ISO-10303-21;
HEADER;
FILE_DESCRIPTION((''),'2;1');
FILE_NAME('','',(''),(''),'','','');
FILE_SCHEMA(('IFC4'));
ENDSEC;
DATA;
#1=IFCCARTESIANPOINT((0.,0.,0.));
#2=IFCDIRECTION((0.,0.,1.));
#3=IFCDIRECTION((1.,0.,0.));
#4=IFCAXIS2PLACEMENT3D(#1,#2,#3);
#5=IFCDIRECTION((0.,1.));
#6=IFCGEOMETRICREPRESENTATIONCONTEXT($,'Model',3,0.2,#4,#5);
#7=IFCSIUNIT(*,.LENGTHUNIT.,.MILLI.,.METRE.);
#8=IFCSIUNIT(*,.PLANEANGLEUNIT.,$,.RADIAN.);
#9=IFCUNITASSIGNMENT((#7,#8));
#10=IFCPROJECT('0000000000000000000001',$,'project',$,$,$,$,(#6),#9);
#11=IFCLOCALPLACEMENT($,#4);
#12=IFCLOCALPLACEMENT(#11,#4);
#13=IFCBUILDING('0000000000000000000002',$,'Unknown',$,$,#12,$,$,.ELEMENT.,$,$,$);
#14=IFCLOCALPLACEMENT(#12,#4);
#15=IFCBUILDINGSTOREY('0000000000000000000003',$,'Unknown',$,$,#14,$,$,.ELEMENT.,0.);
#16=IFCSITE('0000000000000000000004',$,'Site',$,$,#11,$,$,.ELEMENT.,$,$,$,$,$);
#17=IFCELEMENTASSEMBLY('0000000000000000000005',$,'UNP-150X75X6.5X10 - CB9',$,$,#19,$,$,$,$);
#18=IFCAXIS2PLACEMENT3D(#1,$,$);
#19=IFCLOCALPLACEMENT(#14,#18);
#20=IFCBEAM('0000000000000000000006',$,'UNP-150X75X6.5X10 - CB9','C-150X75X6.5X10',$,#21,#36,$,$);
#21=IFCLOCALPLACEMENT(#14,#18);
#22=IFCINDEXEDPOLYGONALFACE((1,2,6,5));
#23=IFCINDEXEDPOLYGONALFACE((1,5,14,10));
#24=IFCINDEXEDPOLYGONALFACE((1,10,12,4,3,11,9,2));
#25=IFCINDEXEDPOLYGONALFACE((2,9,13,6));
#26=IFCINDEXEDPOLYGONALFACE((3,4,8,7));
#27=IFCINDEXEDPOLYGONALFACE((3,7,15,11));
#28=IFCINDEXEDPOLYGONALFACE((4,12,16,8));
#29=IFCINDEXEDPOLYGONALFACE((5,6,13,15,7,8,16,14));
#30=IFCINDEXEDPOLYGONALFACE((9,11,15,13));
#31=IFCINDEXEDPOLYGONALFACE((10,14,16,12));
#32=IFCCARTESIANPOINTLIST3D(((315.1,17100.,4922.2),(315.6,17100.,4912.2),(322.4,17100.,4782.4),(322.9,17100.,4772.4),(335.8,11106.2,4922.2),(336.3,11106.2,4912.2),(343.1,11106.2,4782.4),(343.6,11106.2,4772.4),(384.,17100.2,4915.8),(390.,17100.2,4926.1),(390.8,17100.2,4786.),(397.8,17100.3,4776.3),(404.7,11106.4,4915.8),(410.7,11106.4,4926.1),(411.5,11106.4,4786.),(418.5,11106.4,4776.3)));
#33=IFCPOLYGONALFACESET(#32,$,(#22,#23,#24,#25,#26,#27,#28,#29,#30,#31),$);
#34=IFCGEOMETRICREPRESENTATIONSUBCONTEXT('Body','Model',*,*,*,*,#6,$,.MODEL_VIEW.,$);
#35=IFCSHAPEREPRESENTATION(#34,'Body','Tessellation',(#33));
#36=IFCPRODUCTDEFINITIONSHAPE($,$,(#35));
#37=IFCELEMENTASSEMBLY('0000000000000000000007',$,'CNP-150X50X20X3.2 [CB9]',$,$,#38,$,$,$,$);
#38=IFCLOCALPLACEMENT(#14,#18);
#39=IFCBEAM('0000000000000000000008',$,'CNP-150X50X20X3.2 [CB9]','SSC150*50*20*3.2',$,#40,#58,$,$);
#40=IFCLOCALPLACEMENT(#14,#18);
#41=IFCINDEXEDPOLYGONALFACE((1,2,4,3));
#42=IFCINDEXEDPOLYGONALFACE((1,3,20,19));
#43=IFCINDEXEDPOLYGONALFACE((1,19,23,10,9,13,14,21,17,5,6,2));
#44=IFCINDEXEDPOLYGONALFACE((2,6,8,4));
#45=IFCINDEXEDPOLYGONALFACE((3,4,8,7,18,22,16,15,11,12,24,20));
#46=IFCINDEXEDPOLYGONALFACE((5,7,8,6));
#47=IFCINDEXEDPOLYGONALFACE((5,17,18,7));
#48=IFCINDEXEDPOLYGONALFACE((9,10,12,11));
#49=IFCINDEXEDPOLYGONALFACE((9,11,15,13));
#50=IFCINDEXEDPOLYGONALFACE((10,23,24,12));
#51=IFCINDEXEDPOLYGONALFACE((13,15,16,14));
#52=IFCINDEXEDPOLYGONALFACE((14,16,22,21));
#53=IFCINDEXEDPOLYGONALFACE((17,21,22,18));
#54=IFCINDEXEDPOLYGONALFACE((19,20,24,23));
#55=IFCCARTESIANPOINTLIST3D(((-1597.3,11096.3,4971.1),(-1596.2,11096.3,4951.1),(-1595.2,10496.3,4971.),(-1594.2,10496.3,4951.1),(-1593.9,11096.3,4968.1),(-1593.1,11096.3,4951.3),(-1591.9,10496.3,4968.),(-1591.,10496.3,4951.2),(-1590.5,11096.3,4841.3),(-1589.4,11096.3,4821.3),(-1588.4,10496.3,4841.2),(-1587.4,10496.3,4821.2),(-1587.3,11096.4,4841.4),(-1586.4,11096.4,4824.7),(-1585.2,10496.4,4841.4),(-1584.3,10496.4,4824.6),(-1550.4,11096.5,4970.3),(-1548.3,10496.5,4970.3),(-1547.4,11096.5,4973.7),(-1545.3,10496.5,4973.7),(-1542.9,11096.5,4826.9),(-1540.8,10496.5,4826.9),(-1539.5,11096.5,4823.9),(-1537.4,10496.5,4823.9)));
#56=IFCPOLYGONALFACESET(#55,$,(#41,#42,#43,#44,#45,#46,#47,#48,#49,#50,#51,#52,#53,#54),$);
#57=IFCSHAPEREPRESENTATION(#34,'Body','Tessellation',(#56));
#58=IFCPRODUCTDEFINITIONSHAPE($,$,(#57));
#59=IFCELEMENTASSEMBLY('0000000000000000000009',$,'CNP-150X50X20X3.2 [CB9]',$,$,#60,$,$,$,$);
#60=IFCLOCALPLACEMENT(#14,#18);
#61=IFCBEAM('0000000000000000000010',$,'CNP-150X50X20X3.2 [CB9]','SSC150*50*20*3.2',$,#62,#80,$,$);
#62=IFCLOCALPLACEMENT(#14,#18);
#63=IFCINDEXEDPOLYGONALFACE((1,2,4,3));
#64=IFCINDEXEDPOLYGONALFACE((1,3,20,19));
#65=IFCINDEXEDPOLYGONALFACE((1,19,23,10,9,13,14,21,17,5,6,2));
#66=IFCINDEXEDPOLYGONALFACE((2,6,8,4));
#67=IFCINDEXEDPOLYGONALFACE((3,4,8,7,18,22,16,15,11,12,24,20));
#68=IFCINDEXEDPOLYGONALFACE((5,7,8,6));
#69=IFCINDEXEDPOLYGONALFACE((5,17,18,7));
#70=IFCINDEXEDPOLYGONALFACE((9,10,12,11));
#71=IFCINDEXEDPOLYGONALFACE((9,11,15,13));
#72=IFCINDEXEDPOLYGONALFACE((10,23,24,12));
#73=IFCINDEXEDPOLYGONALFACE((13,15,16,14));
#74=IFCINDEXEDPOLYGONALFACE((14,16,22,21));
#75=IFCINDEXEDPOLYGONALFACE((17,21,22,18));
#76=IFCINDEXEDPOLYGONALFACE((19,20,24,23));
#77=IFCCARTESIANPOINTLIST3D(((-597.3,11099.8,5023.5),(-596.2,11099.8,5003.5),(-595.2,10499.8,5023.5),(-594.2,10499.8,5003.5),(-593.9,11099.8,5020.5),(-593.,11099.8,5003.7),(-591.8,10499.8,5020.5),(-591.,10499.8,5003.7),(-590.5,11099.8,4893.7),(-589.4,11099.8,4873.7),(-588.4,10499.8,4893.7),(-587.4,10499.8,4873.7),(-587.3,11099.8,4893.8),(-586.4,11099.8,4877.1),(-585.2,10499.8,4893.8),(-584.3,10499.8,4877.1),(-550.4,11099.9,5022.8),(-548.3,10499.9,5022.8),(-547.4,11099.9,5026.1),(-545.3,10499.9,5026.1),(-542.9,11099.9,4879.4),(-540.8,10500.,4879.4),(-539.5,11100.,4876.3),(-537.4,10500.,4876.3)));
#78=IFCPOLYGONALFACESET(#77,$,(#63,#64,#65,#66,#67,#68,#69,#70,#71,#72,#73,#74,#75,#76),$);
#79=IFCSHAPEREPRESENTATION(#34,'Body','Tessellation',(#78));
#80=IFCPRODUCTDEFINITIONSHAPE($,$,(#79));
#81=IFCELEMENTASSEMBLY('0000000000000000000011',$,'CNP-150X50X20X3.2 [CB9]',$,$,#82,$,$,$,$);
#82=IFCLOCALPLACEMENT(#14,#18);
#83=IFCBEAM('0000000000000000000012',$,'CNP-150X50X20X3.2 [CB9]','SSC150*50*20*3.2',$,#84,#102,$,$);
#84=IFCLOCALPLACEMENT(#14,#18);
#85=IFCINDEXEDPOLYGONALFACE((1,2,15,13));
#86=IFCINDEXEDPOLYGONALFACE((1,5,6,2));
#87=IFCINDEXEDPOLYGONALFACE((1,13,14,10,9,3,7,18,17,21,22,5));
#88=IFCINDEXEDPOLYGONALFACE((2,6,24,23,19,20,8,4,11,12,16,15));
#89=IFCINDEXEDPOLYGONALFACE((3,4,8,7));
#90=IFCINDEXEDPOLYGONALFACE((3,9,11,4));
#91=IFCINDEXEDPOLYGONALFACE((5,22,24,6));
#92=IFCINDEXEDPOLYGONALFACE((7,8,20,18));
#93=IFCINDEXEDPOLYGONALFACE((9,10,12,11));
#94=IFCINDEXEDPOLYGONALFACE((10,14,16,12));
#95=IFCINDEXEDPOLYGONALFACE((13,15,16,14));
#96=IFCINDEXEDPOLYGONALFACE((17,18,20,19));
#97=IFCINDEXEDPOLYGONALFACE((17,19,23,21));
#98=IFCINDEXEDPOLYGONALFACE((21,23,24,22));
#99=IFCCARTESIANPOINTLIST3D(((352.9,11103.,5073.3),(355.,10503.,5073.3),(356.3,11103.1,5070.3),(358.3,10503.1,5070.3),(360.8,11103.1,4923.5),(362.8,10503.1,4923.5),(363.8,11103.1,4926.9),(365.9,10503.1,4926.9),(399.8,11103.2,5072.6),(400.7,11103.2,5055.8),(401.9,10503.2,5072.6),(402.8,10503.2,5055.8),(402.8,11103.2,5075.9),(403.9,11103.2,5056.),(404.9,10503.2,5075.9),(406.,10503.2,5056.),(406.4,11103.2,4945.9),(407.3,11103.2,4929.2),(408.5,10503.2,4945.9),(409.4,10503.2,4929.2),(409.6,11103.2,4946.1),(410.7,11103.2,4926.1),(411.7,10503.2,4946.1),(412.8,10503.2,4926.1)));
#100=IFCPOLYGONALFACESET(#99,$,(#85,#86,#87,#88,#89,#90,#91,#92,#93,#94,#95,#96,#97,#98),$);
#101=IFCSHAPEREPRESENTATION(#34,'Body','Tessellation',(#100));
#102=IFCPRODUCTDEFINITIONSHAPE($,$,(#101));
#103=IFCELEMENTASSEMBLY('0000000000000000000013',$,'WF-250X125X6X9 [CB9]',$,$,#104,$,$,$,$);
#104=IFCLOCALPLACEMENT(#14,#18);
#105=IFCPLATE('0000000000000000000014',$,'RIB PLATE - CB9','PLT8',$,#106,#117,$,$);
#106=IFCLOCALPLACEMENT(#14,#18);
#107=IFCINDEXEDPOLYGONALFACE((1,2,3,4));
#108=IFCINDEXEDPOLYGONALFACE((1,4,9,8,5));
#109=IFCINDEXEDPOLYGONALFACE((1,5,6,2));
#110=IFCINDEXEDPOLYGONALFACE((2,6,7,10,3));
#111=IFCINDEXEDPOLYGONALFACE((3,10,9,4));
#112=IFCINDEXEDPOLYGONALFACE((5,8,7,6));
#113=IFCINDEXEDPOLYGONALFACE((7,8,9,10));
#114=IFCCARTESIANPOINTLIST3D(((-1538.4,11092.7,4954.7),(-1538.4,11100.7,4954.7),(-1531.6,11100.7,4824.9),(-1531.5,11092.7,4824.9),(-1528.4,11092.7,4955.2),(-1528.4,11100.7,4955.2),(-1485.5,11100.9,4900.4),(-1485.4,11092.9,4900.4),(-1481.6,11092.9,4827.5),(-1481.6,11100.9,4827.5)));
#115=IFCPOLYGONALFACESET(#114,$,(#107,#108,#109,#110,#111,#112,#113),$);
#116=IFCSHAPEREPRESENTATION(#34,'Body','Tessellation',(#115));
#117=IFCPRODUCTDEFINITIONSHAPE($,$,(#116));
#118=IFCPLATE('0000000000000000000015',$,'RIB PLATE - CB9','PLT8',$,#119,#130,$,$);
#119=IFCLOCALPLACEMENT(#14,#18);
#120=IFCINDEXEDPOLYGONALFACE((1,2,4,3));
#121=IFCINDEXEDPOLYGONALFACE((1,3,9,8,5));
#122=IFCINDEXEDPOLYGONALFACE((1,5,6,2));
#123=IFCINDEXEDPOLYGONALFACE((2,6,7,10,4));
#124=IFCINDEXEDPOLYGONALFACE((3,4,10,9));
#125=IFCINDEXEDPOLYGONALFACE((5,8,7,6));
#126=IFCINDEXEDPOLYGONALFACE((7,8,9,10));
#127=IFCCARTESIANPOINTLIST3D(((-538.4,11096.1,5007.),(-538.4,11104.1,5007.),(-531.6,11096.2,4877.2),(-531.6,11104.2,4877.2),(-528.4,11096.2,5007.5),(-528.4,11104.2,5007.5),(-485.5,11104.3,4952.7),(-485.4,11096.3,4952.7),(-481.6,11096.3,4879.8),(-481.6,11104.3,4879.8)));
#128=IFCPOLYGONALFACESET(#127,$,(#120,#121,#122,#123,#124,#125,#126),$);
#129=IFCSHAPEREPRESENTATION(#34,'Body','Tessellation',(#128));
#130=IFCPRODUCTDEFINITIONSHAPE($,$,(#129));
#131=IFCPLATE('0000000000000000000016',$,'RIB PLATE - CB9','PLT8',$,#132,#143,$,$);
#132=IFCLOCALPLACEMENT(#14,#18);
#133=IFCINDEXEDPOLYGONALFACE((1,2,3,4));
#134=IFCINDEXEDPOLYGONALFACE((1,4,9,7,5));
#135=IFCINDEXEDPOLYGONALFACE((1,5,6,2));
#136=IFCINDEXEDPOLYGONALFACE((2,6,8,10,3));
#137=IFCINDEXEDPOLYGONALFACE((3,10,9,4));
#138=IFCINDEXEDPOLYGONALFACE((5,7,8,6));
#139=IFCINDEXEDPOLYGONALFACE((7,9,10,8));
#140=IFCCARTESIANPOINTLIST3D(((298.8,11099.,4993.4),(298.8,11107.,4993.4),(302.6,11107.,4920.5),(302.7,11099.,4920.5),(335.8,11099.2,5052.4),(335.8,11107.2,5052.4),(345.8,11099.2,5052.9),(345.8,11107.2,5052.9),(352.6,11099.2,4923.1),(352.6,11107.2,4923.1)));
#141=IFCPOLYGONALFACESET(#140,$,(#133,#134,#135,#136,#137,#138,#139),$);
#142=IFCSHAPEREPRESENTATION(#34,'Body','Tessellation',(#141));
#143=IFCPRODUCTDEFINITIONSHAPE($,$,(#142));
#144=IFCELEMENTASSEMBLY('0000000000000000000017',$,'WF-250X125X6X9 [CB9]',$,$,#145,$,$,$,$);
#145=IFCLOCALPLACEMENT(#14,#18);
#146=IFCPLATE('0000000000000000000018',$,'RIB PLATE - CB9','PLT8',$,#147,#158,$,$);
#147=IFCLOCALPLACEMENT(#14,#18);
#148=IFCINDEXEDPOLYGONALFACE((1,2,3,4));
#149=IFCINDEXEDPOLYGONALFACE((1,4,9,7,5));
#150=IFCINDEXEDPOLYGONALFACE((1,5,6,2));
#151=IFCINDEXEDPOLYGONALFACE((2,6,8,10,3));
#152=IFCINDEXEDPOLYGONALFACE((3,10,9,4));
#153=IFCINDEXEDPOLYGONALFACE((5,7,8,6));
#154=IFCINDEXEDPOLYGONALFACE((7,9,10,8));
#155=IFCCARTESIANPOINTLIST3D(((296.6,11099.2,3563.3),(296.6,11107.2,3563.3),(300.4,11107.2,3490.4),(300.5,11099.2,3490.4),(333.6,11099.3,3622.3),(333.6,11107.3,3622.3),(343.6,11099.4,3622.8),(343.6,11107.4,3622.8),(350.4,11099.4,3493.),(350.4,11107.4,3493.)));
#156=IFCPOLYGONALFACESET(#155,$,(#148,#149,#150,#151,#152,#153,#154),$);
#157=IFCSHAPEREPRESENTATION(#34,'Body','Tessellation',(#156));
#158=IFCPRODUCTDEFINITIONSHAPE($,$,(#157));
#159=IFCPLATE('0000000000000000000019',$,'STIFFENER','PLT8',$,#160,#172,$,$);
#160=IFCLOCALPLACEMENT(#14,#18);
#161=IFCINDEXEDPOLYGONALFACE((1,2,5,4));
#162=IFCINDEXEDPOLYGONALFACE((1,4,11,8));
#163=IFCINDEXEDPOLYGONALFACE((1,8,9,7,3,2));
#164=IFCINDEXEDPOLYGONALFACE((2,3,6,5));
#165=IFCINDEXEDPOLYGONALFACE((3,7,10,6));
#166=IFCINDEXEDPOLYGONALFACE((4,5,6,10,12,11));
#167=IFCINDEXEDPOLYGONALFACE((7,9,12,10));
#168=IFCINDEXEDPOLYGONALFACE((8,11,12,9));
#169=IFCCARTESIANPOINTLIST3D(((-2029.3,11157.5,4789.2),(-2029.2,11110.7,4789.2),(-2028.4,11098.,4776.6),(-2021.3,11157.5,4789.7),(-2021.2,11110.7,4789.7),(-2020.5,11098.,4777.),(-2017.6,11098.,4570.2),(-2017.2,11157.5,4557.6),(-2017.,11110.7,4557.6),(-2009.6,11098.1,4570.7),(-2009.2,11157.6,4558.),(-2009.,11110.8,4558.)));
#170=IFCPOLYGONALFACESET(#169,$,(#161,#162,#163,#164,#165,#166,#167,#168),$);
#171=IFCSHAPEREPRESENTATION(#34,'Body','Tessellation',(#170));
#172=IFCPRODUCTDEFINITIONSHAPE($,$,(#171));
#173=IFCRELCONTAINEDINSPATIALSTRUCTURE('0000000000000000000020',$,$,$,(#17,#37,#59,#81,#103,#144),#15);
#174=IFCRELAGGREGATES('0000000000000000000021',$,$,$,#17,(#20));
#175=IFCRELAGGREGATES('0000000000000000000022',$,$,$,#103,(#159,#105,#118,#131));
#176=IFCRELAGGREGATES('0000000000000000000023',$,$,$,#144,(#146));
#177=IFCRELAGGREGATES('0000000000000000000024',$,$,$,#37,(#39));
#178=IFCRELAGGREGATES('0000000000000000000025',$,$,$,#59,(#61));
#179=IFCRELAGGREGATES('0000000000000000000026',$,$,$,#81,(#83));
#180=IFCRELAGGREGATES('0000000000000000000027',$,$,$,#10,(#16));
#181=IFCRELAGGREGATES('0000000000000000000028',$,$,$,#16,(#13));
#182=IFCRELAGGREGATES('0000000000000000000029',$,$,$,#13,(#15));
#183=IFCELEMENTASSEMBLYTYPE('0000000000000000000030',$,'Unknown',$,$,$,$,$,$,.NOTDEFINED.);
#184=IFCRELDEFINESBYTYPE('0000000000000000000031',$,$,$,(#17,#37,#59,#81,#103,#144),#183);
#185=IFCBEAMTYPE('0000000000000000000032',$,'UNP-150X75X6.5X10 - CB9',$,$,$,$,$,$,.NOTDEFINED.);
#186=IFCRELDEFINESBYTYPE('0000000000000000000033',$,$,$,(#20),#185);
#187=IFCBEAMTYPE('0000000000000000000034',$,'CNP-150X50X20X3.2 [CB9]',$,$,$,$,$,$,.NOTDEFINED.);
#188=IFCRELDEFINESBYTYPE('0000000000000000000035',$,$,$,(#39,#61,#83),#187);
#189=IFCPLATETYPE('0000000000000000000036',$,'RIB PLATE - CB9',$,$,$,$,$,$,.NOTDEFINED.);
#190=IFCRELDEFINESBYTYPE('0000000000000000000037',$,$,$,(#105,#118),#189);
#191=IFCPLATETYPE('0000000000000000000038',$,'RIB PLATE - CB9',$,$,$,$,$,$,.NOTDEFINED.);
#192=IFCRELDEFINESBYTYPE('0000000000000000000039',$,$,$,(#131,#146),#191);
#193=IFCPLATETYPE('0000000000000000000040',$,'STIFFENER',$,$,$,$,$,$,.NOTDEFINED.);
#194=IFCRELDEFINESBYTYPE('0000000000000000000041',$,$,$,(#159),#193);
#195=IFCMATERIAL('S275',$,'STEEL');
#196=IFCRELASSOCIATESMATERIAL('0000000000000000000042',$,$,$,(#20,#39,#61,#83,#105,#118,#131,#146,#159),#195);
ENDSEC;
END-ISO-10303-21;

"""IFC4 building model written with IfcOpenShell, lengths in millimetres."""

from ifc_helpers import new_model, si_unit, direction, frame, origin_with_axes, origin_2d_with_axis, place, context, subcontext, project, spatial, polyline, line, indexed_curve, c_section, outline, extrude, material, material_profile, profile_set, profile_usage, type_object, element, aggregate, save


model = new_model("IFC4")

# Units and contexts
model_context = context("Model", 3, precision=0.2, world=origin_with_axes(), true_north=direction((0.0, 1.0)))
body_context = subcontext(model_context, "Body", "Model", "MODEL_VIEW")
ifc_project = project(units=[si_unit("LENGTHUNIT", "METRE", prefix="MILLI"), si_unit("PLANEANGLEUNIT", "RADIAN")], contexts=[model_context])

# Site, building, storey
site_placement = place(None, origin_with_axes())
site = spatial("IfcSite", under=ifc_project, at=site_placement, Name="Site", CompositionType="ELEMENT")
building_placement = place(site_placement, origin_with_axes())
building = spatial("IfcBuilding", under=site, at=building_placement, Name="Unknown", CompositionType="ELEMENT")
storey_placement = place(building_placement, origin_with_axes())
storey = spatial("IfcBuildingStorey", under=building, at=storey_placement, Name="Unknown", CompositionType="ELEMENT", Elevation=0.0)

# Element assemblies, beams
element_assembly_type = type_object("IfcElementAssemblyType", Name="Unknown", PredefinedType="NOTDEFINED")
assembly_1_placement = place(storey_placement, frame((377.1, 11106.3, 4849.3), z_axis=(-0.998624, -0.003447, -0.052336), x_axis=(-0.003452, 0.999994, 0.0)))
assembly_1 = element("IfcElementAssembly", 1, at=assembly_1_placement, inside=storey, type_object=element_assembly_type, Name="UNP-150X75X6.5X10 - CB9")
ifc_material_1 = material(Name="S275", Category="STEEL")
ifc_material_profile_1 = material_profile(ifc_material_1, outline(polyline([(-37.5, -75.0), (37.5, -75.0), (37.5, -65.0), (-31.0, -65.0), (-31.0, 65.0), (37.5, 65.0), (37.5, 75.0), (-37.5, 75.0), (-37.5, -75.0)])), Name="C-150X75X6.5X10")
ifc_profile_set_1 = profile_set([ifc_material_profile_1])
ifc_profile_usage_1 = profile_usage(ifc_profile_set_1, cardinal=8)
beam_type_1 = type_object("IfcBeamType", Name="UNP-150X75X6.5X10 - CB9", PredefinedType="NOTDEFINED")
beam_1_placement = place(assembly_1_placement, origin_with_axes())
beam_1 = element("IfcBeam", 2, at=beam_1_placement, type_object=beam_type_1, material=ifc_profile_usage_1, Name="UNP-150X75X6.5X10 - CB9", Description="C-150X75X6.5X10", context=body_context, shape_type="SolidModel", body=[
    extrude(outline(polyline([(-37.5, -75.0), (37.5, -75.0), (37.5, -65.0), (-31.0, -65.0), (-31.0, 65.0), (37.5, 65.0), (37.5, 75.0), (-37.5, 75.0), (-37.5, -75.0)])), frame((0.0, 0.0, 0.0), z_axis=(-1.0, 0.0, 0.0), x_axis=(0.0, 0.0, 1.0)), (0.0, 0.0, -1.0), 5993.9),
])
aggregate(assembly_1, [beam_1])
assembly_2_placement = place(storey_placement, frame((-1568.4, 11096.4, 4897.5), z_axis=(-0.998624, -0.003452, -0.052336), x_axis=(0.003461, -0.999994, -0.000087)))
assembly_2 = element("IfcElementAssembly", 3, at=assembly_2_placement, inside=storey, type_object=element_assembly_type, Name="CNP-150X50X20X3.2 [CB9]")
ifc_material_profile_2 = material_profile(ifc_material_1, c_section(Depth=150.0, Width=50.0, WallThickness=3.2, Girth=20.0, at=origin_2d_with_axis()), Name="SSC150*50*20*3.2")
ifc_profile_set_2 = profile_set([ifc_material_profile_2])
ifc_profile_usage_2 = profile_usage(ifc_profile_set_2, cardinal=8)
beam_type_2 = type_object("IfcBeamType", Name="CNP-150X50X20X3.2 [CB9]", PredefinedType="NOTDEFINED")
beam_2_placement = place(assembly_2_placement, origin_with_axes())
beam_2 = element("IfcBeam", 4, at=beam_2_placement, type_object=beam_type_2, material=ifc_profile_usage_2, Name="CNP-150X50X20X3.2 [CB9]", Description="SSC150*50*20*3.2", context=body_context, shape_type="SolidModel", body=[
    extrude(c_section(Depth=150.0, Width=50.0, WallThickness=3.2, Girth=20.0, at=origin_2d_with_axis()), frame((0.0, 0.0, 0.0), z_axis=(-1.0, 0.0, 0.0), x_axis=(0.0, 0.0, 1.0)), (0.0, 0.0, -1.0), 600.0),
])
assembly_3_placement = place(storey_placement, frame((-568.4, 11099.9, 4949.9), z_axis=(-0.998624, -0.003452, -0.052336), x_axis=(0.003456, -0.999994, 0.0)))
assembly_3 = element("IfcElementAssembly", 5, at=assembly_3_placement, inside=storey, type_object=element_assembly_type, Name="CNP-150X50X20X3.2 [CB9]")
beam_3_placement = place(assembly_3_placement, origin_with_axes())
beam_3 = element("IfcBeam", 6, at=beam_3_placement, type_object=beam_type_2, material=ifc_profile_usage_2, Name="CNP-150X50X20X3.2 [CB9]", Description="SSC150*50*20*3.2", context=body_context, shape_type="SolidModel", body=[
    extrude(c_section(Depth=150.0, Width=50.0, WallThickness=3.2, Girth=20.0, at=origin_2d_with_axis()), frame((0.0, 0.0, 0.0), z_axis=(-1.0, 0.0, 0.0), x_axis=(0.0, 0.0, 1.0)), (0.0, 0.0, -1.0), 600.0),
])
assembly_4_placement = place(storey_placement, frame((381.8, 11103.1, 4999.7), z_axis=(0.998624, 0.003441, 0.052336), x_axis=(0.003445, -0.999994, -0.000001)))
assembly_4 = element("IfcElementAssembly", 7, at=assembly_4_placement, inside=storey, type_object=element_assembly_type, Name="CNP-150X50X20X3.2 [CB9]")
beam_4_placement = place(assembly_4_placement, origin_with_axes())
beam_4 = element("IfcBeam", 8, at=beam_4_placement, type_object=beam_type_2, material=ifc_profile_usage_2, Name="CNP-150X50X20X3.2 [CB9]", Description="SSC150*50*20*3.2", context=body_context, shape_type="SolidModel", body=[
    extrude(c_section(Depth=150.0, Width=50.0, WallThickness=3.2, Girth=20.0, at=origin_2d_with_axis()), frame((0.0, 0.0, 0.0), z_axis=(-1.0, 0.0, 0.0), x_axis=(0.0, 0.0, 1.0)), (0.0, 0.0, -1.0), 600.0),
])

# Element assembly, plates
assembly_5_placement = place(storey_placement, frame((-2227.5, 11094.3, 4662.7), z_axis=(0.003456, -0.999994, 0.0), x_axis=(0.998624, 0.003452, 0.052336)))
assembly_5 = element("IfcElementAssembly", 9, at=assembly_5_placement, inside=storey, type_object=element_assembly_type, Name="WF-250X125X6X9 [CB9]")
ifc_material_profile_3 = material_profile(ifc_material_1, outline(indexed_curve([(0.0, 0.0), (130.0, 0.0), (130.0, 10.0), (73.0, 50.0), (0.0, 50.0)], segments=[line(1, 2, 3, 4, 5, 1)])), Name="PLT8")
ifc_profile_set_3 = profile_set([ifc_material_profile_3])
ifc_profile_usage_3 = profile_usage(ifc_profile_set_3, cardinal=5)
plate_type_1 = type_object("IfcPlateType", Name="RIB PLATE - CB9", PredefinedType="NOTDEFINED")
plate_1_placement = place(assembly_5_placement, frame((703.4, 125.5, 0.0), z_axis=(0.0, 0.0, -1.0), x_axis=(0.0, 1.0, 0.0)))
plate_1 = element("IfcPlate", 10, at=plate_1_placement, type_object=plate_type_1, material=ifc_profile_usage_3, Name="RIB PLATE - CB9", Description="PLT8", context=body_context, shape_type="SolidModel", body=[
    extrude(outline(indexed_curve([(0.0, 0.0), (130.0, 0.0), (130.0, 10.0), (73.0, 50.0), (0.0, 50.0)], segments=[line(1, 2, 3, 4, 5, 1)])), frame((0.0, 0.0, 4.0), z_axis=(0.0, 0.0, 1.0), x_axis=(1.0, 0.0, 0.0)), (0.0, 0.0, -1.0), 8.0),
])
plate_2_placement = place(assembly_5_placement, frame((1704.8, 125.4, 0.0), z_axis=(0.0, 0.0, -1.0), x_axis=(0.0, 1.0, 0.0)))
plate_2 = element("IfcPlate", 11, at=plate_2_placement, type_object=plate_type_1, material=ifc_profile_usage_3, Name="RIB PLATE - CB9", Description="PLT8", context=body_context, shape_type="SolidModel", body=[
    extrude(outline(indexed_curve([(0.0, 0.0), (130.0, 0.0), (130.0, 10.0), (73.0, 50.0), (0.0, 50.0)], segments=[line(1, 2, 3, 4, 5, 1)])), frame((0.0, 0.0, 4.0), z_axis=(0.0, 0.0, 1.0), x_axis=(1.0, 0.0, 0.0)), (0.0, 0.0, -1.0), 8.0),
])
ifc_material_profile_4 = material_profile(ifc_material_1, outline(indexed_curve([(0.0, 0.0), (130.0, 0.0), (130.0, 50.0), (57.0, 50.0), (0.0, 10.0)], segments=[line(1, 2, 3, 4, 5, 1)])), Name="PLT8")
ifc_profile_set_4 = profile_set([ifc_material_profile_4])
ifc_profile_usage_4 = profile_usage(ifc_profile_set_4, cardinal=5)
plate_type_2 = type_object("IfcPlateType", Name="RIB PLATE - CB9", PredefinedType="NOTDEFINED")
plate_3_placement = place(assembly_5_placement, frame((2590.2, 255.0, 0.0), z_axis=(0.0, 0.0, -1.0), x_axis=(0.0, -1.0, 0.0)))
plate_3 = element("IfcPlate", 12, at=plate_3_placement, type_object=plate_type_2, material=ifc_profile_usage_4, Name="RIB PLATE - CB9", Description="PLT8", context=body_context, shape_type="SolidModel", body=[
    extrude(outline(indexed_curve([(0.0, 0.0), (130.0, 0.0), (130.0, 50.0), (57.0, 50.0), (0.0, 10.0)], segments=[line(1, 2, 3, 4, 5, 1)])), frame((0.0, 0.0, 4.0), z_axis=(0.0, 0.0, 1.0), x_axis=(1.0, 0.0, 0.0)), (0.0, 0.0, -1.0), 8.0),
])

# Element assembly, plate
assembly_6_placement = place(storey_placement, frame((-2191.6, 11094.6, 3234.7), z_axis=(-0.003456, 0.999994, 0.0), x_axis=(0.998601, 0.003452, 0.052758)))
assembly_6 = element("IfcElementAssembly", 13, at=assembly_6_placement, inside=storey, type_object=element_assembly_type, Name="WF-250X125X6X9 [CB9]")
plate_4_placement = place(assembly_6_placement, frame((2552.1, -253.8, 0.0), z_axis=(0.0, 0.0, 1.0), x_axis=(-0.000422, 1.0, 0.0)))
plate_4 = element("IfcPlate", 14, at=plate_4_placement, type_object=plate_type_2, material=ifc_profile_usage_4, Name="RIB PLATE - CB9", Description="PLT8", context=body_context, shape_type="SolidModel", body=[
    extrude(outline(indexed_curve([(0.0, 0.0), (130.0, 0.0), (130.0, 50.0), (57.0, 50.0), (0.0, 10.0)], segments=[line(1, 2, 3, 4, 5, 1)])), frame((0.0, 0.0, 4.0), z_axis=(0.0, 0.0, 1.0), x_axis=(1.0, 0.0, 0.0)), (0.0, 0.0, -1.0), 8.0),
])

# Plate
ifc_material_profile_5 = material_profile(ifc_material_1, outline(indexed_curve([(0.0, 12.7), (12.7, 0.0), (59.5, 0.0), (59.5, 232.0), (12.7, 232.0), (0.0, 219.3)], segments=[line(1, 2, 3, 4, 5, 6, 1)])), Name="PLT8")
ifc_profile_set_5 = profile_set([ifc_material_profile_5])
ifc_profile_usage_5 = profile_usage(ifc_profile_set_5, cardinal=2)
plate_type_3 = type_object("IfcPlateType", Name="STIFFENER", PredefinedType="NOTDEFINED")
plate_5_placement = place(assembly_5_placement, frame((208.7, 116.0, -3.0), z_axis=(-1.0, 0.0, 0.0), x_axis=(0.0, 0.0, -1.0)))
plate_5 = element("IfcPlate", 15, at=plate_5_placement, type_object=plate_type_3, material=ifc_profile_usage_5, Name="STIFFENER", Description="PLT8", context=body_context, shape_type="SolidModel", body=[
    extrude(outline(indexed_curve([(0.0, 12.7), (12.7, 0.0), (59.5, 0.0), (59.5, 232.0), (12.7, 232.0), (0.0, 219.3)], segments=[line(1, 2, 3, 4, 5, 6, 1)])), frame((0.0, 0.0, 4.0), z_axis=(0.0, 0.0, 1.0), x_axis=(1.0, 0.0, 0.0)), (0.0, 0.0, -1.0), 8.0),
])
aggregate(assembly_5, [plate_5, plate_1, plate_2, plate_3])
aggregate(assembly_6, [plate_4])

aggregate(assembly_2, [beam_2])
aggregate(assembly_3, [beam_3])

aggregate(assembly_4, [beam_4])

save(model, "model.ifc")
